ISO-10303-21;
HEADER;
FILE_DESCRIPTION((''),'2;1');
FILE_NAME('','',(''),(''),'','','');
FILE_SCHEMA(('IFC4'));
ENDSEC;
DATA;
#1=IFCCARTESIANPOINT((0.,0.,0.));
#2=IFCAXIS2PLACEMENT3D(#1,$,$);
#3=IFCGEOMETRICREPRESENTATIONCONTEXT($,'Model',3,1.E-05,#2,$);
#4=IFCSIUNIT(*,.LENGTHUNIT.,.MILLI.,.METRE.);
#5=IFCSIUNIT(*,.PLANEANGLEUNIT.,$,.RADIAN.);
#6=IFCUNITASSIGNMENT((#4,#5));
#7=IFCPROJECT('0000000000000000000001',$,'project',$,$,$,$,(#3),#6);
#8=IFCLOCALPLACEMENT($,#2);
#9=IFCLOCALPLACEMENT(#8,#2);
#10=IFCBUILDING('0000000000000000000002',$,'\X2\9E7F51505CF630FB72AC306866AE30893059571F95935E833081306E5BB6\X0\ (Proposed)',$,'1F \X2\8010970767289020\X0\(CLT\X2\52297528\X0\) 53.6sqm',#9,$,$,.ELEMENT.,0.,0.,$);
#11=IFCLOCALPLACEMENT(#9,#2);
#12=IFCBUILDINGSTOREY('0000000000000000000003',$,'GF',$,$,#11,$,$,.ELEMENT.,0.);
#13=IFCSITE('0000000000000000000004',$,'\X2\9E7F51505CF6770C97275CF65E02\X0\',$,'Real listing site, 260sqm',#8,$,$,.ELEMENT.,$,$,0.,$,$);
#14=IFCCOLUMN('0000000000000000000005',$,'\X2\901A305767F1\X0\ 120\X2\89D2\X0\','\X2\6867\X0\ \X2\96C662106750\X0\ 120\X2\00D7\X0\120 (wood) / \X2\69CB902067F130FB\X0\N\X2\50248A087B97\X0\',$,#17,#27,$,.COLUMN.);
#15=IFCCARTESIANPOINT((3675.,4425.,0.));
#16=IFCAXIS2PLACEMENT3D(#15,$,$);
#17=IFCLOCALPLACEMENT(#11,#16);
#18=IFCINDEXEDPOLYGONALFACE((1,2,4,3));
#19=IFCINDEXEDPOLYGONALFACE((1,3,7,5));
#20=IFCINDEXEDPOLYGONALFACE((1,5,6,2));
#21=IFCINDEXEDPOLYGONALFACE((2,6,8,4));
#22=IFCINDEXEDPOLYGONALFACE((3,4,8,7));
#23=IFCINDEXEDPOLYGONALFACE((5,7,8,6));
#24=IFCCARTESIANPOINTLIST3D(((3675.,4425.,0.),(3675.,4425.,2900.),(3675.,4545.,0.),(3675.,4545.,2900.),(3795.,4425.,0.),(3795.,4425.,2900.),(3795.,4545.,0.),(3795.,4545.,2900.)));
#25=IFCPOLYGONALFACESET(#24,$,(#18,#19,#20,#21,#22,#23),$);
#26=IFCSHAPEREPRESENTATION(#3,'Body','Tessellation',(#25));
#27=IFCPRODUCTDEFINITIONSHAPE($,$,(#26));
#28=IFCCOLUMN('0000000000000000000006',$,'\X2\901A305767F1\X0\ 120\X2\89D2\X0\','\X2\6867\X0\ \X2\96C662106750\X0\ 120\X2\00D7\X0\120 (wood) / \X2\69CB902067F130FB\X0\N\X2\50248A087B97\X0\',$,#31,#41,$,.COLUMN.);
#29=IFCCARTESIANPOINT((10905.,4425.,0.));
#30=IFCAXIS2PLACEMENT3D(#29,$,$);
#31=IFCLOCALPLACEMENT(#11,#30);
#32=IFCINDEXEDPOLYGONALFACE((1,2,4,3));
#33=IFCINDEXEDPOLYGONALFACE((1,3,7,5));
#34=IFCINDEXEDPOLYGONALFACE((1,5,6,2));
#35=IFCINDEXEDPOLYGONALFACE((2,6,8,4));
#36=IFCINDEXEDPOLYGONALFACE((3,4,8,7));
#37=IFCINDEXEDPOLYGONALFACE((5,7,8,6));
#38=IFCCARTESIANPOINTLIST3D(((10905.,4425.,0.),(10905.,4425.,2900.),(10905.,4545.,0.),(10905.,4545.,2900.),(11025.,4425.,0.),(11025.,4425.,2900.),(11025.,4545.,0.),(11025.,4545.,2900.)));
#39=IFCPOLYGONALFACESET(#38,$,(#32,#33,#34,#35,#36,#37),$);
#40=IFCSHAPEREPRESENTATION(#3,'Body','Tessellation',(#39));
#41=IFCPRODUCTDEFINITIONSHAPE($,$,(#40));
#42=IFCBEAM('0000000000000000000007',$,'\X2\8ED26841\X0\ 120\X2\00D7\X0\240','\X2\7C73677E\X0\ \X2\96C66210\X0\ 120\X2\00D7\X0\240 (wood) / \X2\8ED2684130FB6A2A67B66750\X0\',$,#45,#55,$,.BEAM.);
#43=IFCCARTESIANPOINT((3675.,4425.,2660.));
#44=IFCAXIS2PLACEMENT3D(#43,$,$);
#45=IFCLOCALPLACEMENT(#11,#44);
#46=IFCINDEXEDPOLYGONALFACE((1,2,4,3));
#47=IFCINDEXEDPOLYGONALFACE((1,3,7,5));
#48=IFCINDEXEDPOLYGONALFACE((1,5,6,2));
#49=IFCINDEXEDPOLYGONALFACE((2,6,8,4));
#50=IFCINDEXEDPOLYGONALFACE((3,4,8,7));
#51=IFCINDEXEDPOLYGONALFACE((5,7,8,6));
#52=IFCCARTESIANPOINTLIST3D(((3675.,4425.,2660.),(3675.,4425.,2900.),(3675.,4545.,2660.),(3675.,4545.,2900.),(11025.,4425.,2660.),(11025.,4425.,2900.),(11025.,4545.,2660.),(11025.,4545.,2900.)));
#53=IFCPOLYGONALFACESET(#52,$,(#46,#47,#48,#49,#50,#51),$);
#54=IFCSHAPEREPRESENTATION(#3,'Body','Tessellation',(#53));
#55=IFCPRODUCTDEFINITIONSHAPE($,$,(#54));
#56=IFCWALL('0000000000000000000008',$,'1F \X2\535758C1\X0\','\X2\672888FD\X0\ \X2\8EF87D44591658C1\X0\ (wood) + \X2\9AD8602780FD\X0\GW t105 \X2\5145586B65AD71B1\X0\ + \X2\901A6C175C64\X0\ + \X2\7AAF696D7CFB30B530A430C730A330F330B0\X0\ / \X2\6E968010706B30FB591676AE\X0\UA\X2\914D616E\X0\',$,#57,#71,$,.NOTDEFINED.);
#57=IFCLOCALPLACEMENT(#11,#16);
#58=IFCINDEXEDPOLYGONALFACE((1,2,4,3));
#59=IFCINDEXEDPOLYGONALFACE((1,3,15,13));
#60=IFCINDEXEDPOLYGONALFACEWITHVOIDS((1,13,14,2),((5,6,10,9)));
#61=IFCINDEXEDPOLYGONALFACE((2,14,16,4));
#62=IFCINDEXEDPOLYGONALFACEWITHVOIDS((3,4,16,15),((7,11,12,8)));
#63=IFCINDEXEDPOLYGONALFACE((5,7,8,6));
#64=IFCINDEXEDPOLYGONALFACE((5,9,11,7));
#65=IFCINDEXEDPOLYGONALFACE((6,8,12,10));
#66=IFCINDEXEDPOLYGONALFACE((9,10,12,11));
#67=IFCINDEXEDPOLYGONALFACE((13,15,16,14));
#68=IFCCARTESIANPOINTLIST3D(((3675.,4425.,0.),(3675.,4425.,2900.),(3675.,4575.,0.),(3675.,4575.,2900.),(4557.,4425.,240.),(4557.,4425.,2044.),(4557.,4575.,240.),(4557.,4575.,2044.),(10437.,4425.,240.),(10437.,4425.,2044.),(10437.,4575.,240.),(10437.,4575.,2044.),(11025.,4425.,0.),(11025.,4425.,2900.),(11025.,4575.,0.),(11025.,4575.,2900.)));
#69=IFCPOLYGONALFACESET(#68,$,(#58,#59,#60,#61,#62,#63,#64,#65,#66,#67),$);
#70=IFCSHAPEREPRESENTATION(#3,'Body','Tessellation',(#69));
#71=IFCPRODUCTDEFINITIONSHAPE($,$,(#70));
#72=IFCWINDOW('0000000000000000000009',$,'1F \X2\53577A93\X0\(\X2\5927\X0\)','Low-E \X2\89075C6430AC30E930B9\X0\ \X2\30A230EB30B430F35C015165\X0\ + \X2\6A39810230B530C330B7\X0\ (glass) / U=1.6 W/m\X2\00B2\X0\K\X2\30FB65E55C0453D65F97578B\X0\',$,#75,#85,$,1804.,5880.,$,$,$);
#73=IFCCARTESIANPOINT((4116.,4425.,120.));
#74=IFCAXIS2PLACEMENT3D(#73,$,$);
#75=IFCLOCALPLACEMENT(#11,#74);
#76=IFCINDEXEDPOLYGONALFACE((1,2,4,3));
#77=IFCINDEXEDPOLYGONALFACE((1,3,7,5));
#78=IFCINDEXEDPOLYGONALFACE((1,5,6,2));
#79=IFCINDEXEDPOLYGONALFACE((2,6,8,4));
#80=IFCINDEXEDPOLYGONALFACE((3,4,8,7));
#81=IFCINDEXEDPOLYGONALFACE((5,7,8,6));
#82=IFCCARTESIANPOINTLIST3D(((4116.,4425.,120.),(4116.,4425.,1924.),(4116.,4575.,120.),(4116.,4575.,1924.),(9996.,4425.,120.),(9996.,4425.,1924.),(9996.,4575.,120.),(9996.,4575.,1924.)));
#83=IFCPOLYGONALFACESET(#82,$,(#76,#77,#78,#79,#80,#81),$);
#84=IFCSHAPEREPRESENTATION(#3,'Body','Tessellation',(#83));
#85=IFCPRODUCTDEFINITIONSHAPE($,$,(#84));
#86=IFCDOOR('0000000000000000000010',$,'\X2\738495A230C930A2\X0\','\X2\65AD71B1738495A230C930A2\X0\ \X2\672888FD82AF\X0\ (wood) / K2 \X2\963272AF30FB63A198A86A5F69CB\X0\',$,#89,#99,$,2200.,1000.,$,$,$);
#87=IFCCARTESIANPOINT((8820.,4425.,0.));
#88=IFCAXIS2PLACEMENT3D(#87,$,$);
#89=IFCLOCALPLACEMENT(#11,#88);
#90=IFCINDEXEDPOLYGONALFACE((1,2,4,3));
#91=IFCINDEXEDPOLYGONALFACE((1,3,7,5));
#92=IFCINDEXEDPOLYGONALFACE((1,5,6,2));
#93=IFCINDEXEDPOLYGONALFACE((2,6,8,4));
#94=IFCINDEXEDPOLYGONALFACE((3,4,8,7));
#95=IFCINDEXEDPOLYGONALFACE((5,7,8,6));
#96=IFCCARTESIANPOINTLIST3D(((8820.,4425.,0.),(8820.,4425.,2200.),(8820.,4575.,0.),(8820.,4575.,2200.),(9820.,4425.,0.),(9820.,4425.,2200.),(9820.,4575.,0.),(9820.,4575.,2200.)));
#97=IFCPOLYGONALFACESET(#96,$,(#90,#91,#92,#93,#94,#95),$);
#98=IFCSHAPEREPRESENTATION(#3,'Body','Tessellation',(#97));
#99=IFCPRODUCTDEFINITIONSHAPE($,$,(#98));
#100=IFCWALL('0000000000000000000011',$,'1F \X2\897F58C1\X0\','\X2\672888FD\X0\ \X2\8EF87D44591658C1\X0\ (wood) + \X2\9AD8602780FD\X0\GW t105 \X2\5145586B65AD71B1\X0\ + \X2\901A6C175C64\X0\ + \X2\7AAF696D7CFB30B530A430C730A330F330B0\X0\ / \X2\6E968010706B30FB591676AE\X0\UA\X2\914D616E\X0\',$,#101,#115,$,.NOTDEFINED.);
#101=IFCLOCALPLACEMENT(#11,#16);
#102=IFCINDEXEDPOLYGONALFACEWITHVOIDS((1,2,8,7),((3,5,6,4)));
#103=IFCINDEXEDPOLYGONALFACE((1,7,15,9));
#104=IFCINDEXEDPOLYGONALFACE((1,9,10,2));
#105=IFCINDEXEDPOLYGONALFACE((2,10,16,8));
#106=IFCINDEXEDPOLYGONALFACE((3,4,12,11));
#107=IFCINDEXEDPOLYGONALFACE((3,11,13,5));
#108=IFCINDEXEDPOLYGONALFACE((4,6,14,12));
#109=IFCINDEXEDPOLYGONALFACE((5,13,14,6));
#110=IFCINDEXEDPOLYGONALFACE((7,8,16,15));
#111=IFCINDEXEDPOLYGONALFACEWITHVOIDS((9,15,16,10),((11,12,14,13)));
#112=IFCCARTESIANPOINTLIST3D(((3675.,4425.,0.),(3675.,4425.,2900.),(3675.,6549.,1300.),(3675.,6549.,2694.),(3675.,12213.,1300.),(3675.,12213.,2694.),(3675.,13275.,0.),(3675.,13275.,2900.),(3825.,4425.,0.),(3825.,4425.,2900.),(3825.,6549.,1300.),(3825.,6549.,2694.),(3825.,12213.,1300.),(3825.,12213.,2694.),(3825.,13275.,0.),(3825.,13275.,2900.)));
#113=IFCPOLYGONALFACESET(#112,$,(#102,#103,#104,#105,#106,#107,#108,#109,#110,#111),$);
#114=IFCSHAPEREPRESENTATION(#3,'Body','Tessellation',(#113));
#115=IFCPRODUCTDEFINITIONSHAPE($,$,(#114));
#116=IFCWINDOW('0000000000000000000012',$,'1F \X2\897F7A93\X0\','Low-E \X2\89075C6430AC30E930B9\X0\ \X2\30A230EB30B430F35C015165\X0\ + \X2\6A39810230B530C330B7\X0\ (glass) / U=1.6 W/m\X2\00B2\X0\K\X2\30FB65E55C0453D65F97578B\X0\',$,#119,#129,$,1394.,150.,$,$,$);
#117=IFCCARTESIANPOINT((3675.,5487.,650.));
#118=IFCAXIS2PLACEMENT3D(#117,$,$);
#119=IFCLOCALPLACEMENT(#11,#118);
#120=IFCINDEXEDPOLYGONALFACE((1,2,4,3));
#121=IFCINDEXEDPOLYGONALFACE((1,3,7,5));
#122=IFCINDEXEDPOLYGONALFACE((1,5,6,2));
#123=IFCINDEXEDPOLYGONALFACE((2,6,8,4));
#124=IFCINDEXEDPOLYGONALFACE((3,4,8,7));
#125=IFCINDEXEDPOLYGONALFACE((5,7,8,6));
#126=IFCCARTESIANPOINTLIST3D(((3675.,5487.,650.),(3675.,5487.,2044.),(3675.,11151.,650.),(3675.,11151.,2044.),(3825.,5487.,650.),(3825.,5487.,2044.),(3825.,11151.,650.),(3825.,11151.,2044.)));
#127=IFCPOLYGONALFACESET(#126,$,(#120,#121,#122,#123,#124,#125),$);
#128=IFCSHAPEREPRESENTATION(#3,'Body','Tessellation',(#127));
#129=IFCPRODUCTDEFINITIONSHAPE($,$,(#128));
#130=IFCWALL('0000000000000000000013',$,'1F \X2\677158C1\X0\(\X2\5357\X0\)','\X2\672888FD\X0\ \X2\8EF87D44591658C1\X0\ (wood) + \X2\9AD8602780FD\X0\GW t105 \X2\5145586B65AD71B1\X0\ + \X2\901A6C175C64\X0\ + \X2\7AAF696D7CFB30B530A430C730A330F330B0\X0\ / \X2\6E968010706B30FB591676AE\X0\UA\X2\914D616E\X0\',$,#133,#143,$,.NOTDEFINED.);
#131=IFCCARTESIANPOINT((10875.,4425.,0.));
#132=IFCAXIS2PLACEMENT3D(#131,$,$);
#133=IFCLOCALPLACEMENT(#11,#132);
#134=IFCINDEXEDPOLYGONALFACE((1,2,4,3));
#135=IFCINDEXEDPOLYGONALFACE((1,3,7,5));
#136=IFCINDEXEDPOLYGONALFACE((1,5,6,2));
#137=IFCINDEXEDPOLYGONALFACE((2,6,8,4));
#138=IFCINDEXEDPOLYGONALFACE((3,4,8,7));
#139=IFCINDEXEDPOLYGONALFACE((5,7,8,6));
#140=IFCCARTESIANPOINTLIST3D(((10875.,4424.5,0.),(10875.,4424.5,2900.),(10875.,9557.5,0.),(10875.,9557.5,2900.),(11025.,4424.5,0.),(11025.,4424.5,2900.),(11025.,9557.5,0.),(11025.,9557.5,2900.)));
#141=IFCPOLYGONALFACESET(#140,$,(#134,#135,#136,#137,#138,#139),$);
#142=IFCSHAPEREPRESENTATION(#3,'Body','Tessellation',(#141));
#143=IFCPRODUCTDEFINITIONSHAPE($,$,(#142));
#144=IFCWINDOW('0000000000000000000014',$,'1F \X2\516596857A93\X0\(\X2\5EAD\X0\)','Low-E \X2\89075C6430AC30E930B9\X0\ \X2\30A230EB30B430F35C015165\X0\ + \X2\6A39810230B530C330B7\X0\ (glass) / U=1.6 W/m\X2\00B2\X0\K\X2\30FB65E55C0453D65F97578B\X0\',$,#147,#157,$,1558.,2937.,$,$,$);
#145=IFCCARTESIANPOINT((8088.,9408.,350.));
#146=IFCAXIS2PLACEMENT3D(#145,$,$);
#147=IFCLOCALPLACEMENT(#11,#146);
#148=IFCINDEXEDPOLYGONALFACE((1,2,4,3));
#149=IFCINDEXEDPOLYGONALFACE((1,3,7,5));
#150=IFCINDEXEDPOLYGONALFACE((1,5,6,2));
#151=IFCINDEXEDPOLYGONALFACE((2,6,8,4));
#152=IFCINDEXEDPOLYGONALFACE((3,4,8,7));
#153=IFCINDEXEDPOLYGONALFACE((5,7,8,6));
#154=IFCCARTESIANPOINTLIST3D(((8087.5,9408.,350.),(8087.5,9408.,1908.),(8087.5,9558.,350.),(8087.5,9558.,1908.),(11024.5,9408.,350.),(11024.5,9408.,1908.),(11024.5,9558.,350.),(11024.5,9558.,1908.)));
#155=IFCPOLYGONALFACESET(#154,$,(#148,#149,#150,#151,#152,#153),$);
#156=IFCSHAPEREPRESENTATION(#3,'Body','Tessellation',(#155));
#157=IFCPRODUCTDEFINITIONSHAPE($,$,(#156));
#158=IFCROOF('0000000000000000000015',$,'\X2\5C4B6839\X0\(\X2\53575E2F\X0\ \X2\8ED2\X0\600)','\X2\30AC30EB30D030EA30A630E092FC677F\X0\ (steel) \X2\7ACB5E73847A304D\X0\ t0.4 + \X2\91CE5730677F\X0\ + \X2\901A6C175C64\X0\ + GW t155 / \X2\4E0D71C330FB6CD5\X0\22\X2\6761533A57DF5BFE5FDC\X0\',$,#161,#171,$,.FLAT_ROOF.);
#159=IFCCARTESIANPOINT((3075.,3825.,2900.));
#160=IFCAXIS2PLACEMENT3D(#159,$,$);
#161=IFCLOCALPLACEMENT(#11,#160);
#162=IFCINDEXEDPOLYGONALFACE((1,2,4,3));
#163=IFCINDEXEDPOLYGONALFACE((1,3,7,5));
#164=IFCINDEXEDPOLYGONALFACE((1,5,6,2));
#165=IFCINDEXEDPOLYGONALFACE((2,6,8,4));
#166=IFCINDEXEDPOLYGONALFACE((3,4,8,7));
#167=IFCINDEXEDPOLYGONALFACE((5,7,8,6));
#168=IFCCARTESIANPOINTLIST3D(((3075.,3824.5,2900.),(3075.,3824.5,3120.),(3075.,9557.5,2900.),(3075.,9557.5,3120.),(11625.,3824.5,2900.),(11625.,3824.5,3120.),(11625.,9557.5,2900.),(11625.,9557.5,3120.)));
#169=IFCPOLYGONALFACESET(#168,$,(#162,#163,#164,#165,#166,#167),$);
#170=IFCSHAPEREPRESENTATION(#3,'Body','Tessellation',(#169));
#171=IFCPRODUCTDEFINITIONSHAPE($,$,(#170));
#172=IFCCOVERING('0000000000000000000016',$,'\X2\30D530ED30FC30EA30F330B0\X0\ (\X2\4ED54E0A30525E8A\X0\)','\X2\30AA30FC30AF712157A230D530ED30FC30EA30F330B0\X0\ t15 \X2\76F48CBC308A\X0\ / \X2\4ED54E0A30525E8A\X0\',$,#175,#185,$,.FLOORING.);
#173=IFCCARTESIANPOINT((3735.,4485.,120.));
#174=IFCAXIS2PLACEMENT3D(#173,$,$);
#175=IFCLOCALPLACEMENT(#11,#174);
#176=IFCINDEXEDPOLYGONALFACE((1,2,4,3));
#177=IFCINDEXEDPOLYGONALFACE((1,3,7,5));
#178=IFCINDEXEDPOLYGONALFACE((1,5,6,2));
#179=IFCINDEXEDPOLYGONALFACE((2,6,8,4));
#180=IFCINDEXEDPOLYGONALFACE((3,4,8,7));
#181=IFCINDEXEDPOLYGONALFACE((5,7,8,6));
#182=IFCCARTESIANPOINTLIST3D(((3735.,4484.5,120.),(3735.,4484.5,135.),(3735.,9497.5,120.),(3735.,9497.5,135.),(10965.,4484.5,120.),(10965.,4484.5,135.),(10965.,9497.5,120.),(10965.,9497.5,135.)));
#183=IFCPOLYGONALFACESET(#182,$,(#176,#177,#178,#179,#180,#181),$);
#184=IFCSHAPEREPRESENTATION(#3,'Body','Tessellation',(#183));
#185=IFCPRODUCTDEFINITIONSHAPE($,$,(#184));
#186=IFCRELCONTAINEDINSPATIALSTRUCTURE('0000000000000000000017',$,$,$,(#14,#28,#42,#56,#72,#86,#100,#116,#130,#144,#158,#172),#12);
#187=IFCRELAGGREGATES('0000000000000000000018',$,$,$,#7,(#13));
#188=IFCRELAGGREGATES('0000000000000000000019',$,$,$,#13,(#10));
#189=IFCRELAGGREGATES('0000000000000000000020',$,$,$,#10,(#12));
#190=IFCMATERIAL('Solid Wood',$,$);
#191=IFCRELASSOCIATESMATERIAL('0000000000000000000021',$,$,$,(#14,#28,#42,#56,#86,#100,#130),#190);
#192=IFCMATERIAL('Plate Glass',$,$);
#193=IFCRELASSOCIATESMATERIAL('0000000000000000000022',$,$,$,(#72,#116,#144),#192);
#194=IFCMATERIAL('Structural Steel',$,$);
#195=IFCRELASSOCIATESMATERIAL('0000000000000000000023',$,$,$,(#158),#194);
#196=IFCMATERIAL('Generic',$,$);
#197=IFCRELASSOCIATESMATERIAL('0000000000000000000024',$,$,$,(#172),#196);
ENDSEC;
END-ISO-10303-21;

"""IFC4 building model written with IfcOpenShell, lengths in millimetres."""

from ifc_helpers import new_model, si_unit, frame, frame_2d, origin, place, context, project, spatial, rectangle, extrude, material, element, fill, save


model = new_model("IFC4")

# Units and contexts
model_context = context("Model", 3, precision=1e-05, world=origin())
ifc_project = project(units=[si_unit("LENGTHUNIT", "METRE", prefix="MILLI"), si_unit("PLANEANGLEUNIT", "RADIAN")], contexts=[model_context])

# Site, building, storey
site_placement = place(None, origin())
site = spatial("IfcSite", under=ifc_project, at=site_placement, Name="鹿児島県霧島市", ObjectType="Real listing site, 260sqm", CompositionType="ELEMENT", RefElevation=0.0)
building_placement = place(site_placement, origin())
building = spatial("IfcBuilding", under=site, at=building_placement, Name="鹿児島・犬と暮らす土間広めの家 (Proposed)", ObjectType="1F 耐震木造(CLT利用) 53.6sqm", CompositionType="ELEMENT", ElevationOfRefHeight=0.0, ElevationOfTerrain=0.0)
storey_placement = place(building_placement, origin())
storey = spatial("IfcBuildingStorey", under=building, at=storey_placement, Name="GF", CompositionType="ELEMENT", Elevation=0.0)

# Columns
ifc_material_1 = material(Name="Solid Wood")
column_1_placement = place(storey_placement, frame((3675.0, 4425.0, 0.0)))
element("IfcColumn", 1, at=column_1_placement, inside=storey, material=ifc_material_1, Name="通し柱 120角", Description="桧 集成材 120×120 (wood) / 構造柱・N値計算", PredefinedType="COLUMN", context=model_context, shape_type="SweptSolid", body=[
    extrude(rectangle(XDim=120.0, YDim=120.0, at=frame_2d((60.0, 60.0))), frame((3675.0, 4425.0, 0.0)), (0.0, 0.0, 1.0), 2900.0),
])
column_2_placement = place(storey_placement, frame((10905.0, 4425.0, 0.0)))
element("IfcColumn", 2, at=column_2_placement, inside=storey, material=ifc_material_1, Name="通し柱 120角", Description="桧 集成材 120×120 (wood) / 構造柱・N値計算", PredefinedType="COLUMN", context=model_context, shape_type="SweptSolid", body=[
    extrude(rectangle(XDim=120.0, YDim=120.0, at=frame_2d((60.0, 60.0))), frame((10905.0, 4425.0, 0.0)), (0.0, 0.0, 1.0), 2900.0),
])

# Beam
beam_1_placement = place(storey_placement, frame((3675.0, 4425.0, 2660.0)))
element("IfcBeam", 3, at=beam_1_placement, inside=storey, material=ifc_material_1, Name="軒桁 120×240", Description="米松 集成 120×240 (wood) / 軒桁・横架材", PredefinedType="BEAM", context=model_context, shape_type="SweptSolid", body=[
    extrude(rectangle(XDim=7350.0, YDim=120.0, at=frame_2d((3675.0, 60.0))), frame((3675.0, 4425.0, 2660.0)), (0.0, 0.0, 1.0), 240.0),
])

# Wall, openings, window, door
wall_1_placement = place(storey_placement, frame((3675.0, 4425.0, 0.0)))
wall_1 = element("IfcWall", 4, at=wall_1_placement, inside=storey, material=ifc_material_1, Name="1F 南壁", Description="木製 軸組外壁 (wood) + 高性能GW t105 充填断熱 + 通気層 + 窯業系サイディング / 準耐火・外皮UA配慮", PredefinedType="NOTDEFINED", context=model_context, shape_type="SweptSolid", body=[
    extrude(rectangle(XDim=7350.0, YDim=150.0, at=frame_2d((3675.0, 75.0))), frame((3675.0, 4425.0, 0.0)), (0.0, 0.0, 1.0), 2900.0),
])
opening_1_placement = place(storey_placement, frame((4116.0, 4425.0, 120.0)))
opening_1 = element("IfcOpeningElement", 5, at=opening_1_placement, cuts=wall_1, PredefinedType="NOTDEFINED", context=model_context, shape_type="SweptSolid", body=[
    extrude(rectangle(XDim=5880.0, YDim=150.0, at=frame_2d((2940.0, 75.0))), frame((4116.0, 4425.0, 120.0)), (0.0, 0.0, 1.0), 1804.0),
])
opening_2_placement = place(storey_placement, frame((8820.0, 4425.0, 0.0)))
opening_2 = element("IfcOpeningElement", 6, at=opening_2_placement, cuts=wall_1, PredefinedType="NOTDEFINED", context=model_context, shape_type="SweptSolid", body=[
    extrude(rectangle(XDim=1000.0, YDim=150.0, at=frame_2d((500.0, 75.0))), frame((8820.0, 4425.0, 0.0)), (0.0, 0.0, 1.0), 2200.0),
])
ifc_material_2 = material(Name="Plate Glass")
window_1_placement = place(storey_placement, frame((4116.0, 4425.0, 120.0)))
window_1 = element("IfcWindow", 7, at=window_1_placement, inside=storey, material=ifc_material_2, Name="1F 南窓(大)", Description="Low-E 複層ガラス アルゴン封入 + 樹脂サッシ (glass) / U=1.6 W/m²K・日射取得型", OverallHeight=1804.0, OverallWidth=5880.0, context=model_context, shape_type="SweptSolid", body=[
    extrude(rectangle(XDim=5880.0, YDim=150.0, at=frame_2d((2940.0, 75.0))), frame((4116.0, 4425.0, 120.0)), (0.0, 0.0, 1.0), 1804.0),
])
fill(opening_1, window_1)
door_1_placement = place(storey_placement, frame((8820.0, 4425.0, 0.0)))
door_1 = element("IfcDoor", 8, at=door_1_placement, inside=storey, material=ifc_material_1, Name="玄関ドア", Description="断熱玄関ドア 木製芯 (wood) / K2 防犯・採風機構", OverallHeight=2200.0, OverallWidth=1000.0, context=model_context, shape_type="SweptSolid", body=[
    extrude(rectangle(XDim=1000.0, YDim=150.0, at=frame_2d((500.0, 75.0))), frame((8820.0, 4425.0, 0.0)), (0.0, 0.0, 1.0), 2200.0),
])
fill(opening_2, door_1)

# Walls, openings, windows
wall_2_placement = place(storey_placement, frame((3675.0, 4425.0, 0.0)))
wall_2 = element("IfcWall", 9, at=wall_2_placement, inside=storey, material=ifc_material_1, Name="1F 西壁", Description="木製 軸組外壁 (wood) + 高性能GW t105 充填断熱 + 通気層 + 窯業系サイディング / 準耐火・外皮UA配慮", PredefinedType="NOTDEFINED", context=model_context, shape_type="SweptSolid", body=[
    extrude(rectangle(XDim=150.0, YDim=8850.0, at=frame_2d((75.0, 4425.0))), frame((3675.0, 4425.0, 0.0)), (0.0, 0.0, 1.0), 2900.0),
])
opening_3_placement = place(storey_placement, frame((3675.0, 5487.0, 650.0)))
opening_3 = element("IfcOpeningElement", 10, at=opening_3_placement, cuts=wall_2, PredefinedType="NOTDEFINED", context=model_context, shape_type="SweptSolid", body=[
    extrude(rectangle(XDim=150.0, YDim=5664.0, at=frame_2d((75.0, 2832.0))), frame((3675.0, 5487.0, 650.0)), (0.0, 0.0, 1.0), 1394.0),
])
window_2_placement = place(storey_placement, frame((3675.0, 5487.0, 650.0)))
window_2 = element("IfcWindow", 11, at=window_2_placement, inside=storey, material=ifc_material_2, Name="1F 西窓", Description="Low-E 複層ガラス アルゴン封入 + 樹脂サッシ (glass) / U=1.6 W/m²K・日射取得型", OverallHeight=1394.0, OverallWidth=150.0, context=model_context, shape_type="SweptSolid", body=[
    extrude(rectangle(XDim=150.0, YDim=5664.0, at=frame_2d((75.0, 2832.0))), frame((3675.0, 5487.0, 650.0)), (0.0, 0.0, 1.0), 1394.0),
])
fill(opening_3, window_2)
wall_3_placement = place(storey_placement, frame((10875.0, 4425.0, 0.0)))
wall_3 = element("IfcWall", 12, at=wall_3_placement, inside=storey, material=ifc_material_1, Name="1F 東壁(南)", Description="木製 軸組外壁 (wood) + 高性能GW t105 充填断熱 + 通気層 + 窯業系サイディング / 準耐火・外皮UA配慮", PredefinedType="NOTDEFINED", context=model_context, shape_type="SweptSolid", body=[
    extrude(rectangle(XDim=150.0, YDim=5133.0, at=frame_2d((75.0, 2566.0))), frame((10875.0, 4425.0, 0.0)), (0.0, 0.0, 1.0), 2900.0),
])
opening_4_placement = place(storey_placement, frame((8088.0, 9408.0, 350.0)))
opening_4 = element("IfcOpeningElement", 13, at=opening_4_placement, cuts=wall_3, PredefinedType="NOTDEFINED", context=model_context, shape_type="SweptSolid", body=[
    extrude(rectangle(XDim=2937.0, YDim=150.0, at=frame_2d((1468.0, 75.0))), frame((8088.0, 9408.0, 350.0)), (0.0, 0.0, 1.0), 1558.0),
])
window_3_placement = place(storey_placement, frame((8088.0, 9408.0, 350.0)))
window_3 = element("IfcWindow", 14, at=window_3_placement, inside=storey, material=ifc_material_2, Name="1F 入隅窓(庭)", Description="Low-E 複層ガラス アルゴン封入 + 樹脂サッシ (glass) / U=1.6 W/m²K・日射取得型", OverallHeight=1558.0, OverallWidth=2937.0, context=model_context, shape_type="SweptSolid", body=[
    extrude(rectangle(XDim=2937.0, YDim=150.0, at=frame_2d((1468.0, 75.0))), frame((8088.0, 9408.0, 350.0)), (0.0, 0.0, 1.0), 1558.0),
])
fill(opening_4, window_3)

# Roof
ifc_material_3 = material(Name="Structural Steel")
roof_placement = place(storey_placement, frame((3075.0, 3825.0, 2900.0)))
element("IfcRoof", 15, at=roof_placement, inside=storey, material=ifc_material_3, Name="屋根(南帯 軒600)", Description="ガルバリウム鋼板 (steel) 立平葺き t0.4 + 野地板 + 通気層 + GW t155 / 不燃・法22条区域対応", PredefinedType="FLAT_ROOF", context=model_context, shape_type="SweptSolid", body=[
    extrude(rectangle(XDim=8550.0, YDim=5733.0, at=frame_2d((4275.0, 2866.0))), frame((3075.0, 3825.0, 2900.0)), (0.0, 0.0, 1.0), 220.0),
])

# Covering
ifc_material_4 = material(Name="Generic")
covering_1_placement = place(storey_placement, frame((3735.0, 4485.0, 120.0)))
element("IfcCovering", 16, at=covering_1_placement, inside=storey, material=ifc_material_4, Name="フローリング (仕上げ床)", Description="オーク無垢フローリング t15 直貼り / 仕上げ床", PredefinedType="FLOORING", context=model_context, shape_type="SweptSolid", body=[
    extrude(rectangle(XDim=7230.0, YDim=5013.0, at=frame_2d((3615.0, 2506.0))), frame((3735.0, 4485.0, 120.0)), (0.0, 0.0, 1.0), 15.0),
])

save(model, "model.ifc")
